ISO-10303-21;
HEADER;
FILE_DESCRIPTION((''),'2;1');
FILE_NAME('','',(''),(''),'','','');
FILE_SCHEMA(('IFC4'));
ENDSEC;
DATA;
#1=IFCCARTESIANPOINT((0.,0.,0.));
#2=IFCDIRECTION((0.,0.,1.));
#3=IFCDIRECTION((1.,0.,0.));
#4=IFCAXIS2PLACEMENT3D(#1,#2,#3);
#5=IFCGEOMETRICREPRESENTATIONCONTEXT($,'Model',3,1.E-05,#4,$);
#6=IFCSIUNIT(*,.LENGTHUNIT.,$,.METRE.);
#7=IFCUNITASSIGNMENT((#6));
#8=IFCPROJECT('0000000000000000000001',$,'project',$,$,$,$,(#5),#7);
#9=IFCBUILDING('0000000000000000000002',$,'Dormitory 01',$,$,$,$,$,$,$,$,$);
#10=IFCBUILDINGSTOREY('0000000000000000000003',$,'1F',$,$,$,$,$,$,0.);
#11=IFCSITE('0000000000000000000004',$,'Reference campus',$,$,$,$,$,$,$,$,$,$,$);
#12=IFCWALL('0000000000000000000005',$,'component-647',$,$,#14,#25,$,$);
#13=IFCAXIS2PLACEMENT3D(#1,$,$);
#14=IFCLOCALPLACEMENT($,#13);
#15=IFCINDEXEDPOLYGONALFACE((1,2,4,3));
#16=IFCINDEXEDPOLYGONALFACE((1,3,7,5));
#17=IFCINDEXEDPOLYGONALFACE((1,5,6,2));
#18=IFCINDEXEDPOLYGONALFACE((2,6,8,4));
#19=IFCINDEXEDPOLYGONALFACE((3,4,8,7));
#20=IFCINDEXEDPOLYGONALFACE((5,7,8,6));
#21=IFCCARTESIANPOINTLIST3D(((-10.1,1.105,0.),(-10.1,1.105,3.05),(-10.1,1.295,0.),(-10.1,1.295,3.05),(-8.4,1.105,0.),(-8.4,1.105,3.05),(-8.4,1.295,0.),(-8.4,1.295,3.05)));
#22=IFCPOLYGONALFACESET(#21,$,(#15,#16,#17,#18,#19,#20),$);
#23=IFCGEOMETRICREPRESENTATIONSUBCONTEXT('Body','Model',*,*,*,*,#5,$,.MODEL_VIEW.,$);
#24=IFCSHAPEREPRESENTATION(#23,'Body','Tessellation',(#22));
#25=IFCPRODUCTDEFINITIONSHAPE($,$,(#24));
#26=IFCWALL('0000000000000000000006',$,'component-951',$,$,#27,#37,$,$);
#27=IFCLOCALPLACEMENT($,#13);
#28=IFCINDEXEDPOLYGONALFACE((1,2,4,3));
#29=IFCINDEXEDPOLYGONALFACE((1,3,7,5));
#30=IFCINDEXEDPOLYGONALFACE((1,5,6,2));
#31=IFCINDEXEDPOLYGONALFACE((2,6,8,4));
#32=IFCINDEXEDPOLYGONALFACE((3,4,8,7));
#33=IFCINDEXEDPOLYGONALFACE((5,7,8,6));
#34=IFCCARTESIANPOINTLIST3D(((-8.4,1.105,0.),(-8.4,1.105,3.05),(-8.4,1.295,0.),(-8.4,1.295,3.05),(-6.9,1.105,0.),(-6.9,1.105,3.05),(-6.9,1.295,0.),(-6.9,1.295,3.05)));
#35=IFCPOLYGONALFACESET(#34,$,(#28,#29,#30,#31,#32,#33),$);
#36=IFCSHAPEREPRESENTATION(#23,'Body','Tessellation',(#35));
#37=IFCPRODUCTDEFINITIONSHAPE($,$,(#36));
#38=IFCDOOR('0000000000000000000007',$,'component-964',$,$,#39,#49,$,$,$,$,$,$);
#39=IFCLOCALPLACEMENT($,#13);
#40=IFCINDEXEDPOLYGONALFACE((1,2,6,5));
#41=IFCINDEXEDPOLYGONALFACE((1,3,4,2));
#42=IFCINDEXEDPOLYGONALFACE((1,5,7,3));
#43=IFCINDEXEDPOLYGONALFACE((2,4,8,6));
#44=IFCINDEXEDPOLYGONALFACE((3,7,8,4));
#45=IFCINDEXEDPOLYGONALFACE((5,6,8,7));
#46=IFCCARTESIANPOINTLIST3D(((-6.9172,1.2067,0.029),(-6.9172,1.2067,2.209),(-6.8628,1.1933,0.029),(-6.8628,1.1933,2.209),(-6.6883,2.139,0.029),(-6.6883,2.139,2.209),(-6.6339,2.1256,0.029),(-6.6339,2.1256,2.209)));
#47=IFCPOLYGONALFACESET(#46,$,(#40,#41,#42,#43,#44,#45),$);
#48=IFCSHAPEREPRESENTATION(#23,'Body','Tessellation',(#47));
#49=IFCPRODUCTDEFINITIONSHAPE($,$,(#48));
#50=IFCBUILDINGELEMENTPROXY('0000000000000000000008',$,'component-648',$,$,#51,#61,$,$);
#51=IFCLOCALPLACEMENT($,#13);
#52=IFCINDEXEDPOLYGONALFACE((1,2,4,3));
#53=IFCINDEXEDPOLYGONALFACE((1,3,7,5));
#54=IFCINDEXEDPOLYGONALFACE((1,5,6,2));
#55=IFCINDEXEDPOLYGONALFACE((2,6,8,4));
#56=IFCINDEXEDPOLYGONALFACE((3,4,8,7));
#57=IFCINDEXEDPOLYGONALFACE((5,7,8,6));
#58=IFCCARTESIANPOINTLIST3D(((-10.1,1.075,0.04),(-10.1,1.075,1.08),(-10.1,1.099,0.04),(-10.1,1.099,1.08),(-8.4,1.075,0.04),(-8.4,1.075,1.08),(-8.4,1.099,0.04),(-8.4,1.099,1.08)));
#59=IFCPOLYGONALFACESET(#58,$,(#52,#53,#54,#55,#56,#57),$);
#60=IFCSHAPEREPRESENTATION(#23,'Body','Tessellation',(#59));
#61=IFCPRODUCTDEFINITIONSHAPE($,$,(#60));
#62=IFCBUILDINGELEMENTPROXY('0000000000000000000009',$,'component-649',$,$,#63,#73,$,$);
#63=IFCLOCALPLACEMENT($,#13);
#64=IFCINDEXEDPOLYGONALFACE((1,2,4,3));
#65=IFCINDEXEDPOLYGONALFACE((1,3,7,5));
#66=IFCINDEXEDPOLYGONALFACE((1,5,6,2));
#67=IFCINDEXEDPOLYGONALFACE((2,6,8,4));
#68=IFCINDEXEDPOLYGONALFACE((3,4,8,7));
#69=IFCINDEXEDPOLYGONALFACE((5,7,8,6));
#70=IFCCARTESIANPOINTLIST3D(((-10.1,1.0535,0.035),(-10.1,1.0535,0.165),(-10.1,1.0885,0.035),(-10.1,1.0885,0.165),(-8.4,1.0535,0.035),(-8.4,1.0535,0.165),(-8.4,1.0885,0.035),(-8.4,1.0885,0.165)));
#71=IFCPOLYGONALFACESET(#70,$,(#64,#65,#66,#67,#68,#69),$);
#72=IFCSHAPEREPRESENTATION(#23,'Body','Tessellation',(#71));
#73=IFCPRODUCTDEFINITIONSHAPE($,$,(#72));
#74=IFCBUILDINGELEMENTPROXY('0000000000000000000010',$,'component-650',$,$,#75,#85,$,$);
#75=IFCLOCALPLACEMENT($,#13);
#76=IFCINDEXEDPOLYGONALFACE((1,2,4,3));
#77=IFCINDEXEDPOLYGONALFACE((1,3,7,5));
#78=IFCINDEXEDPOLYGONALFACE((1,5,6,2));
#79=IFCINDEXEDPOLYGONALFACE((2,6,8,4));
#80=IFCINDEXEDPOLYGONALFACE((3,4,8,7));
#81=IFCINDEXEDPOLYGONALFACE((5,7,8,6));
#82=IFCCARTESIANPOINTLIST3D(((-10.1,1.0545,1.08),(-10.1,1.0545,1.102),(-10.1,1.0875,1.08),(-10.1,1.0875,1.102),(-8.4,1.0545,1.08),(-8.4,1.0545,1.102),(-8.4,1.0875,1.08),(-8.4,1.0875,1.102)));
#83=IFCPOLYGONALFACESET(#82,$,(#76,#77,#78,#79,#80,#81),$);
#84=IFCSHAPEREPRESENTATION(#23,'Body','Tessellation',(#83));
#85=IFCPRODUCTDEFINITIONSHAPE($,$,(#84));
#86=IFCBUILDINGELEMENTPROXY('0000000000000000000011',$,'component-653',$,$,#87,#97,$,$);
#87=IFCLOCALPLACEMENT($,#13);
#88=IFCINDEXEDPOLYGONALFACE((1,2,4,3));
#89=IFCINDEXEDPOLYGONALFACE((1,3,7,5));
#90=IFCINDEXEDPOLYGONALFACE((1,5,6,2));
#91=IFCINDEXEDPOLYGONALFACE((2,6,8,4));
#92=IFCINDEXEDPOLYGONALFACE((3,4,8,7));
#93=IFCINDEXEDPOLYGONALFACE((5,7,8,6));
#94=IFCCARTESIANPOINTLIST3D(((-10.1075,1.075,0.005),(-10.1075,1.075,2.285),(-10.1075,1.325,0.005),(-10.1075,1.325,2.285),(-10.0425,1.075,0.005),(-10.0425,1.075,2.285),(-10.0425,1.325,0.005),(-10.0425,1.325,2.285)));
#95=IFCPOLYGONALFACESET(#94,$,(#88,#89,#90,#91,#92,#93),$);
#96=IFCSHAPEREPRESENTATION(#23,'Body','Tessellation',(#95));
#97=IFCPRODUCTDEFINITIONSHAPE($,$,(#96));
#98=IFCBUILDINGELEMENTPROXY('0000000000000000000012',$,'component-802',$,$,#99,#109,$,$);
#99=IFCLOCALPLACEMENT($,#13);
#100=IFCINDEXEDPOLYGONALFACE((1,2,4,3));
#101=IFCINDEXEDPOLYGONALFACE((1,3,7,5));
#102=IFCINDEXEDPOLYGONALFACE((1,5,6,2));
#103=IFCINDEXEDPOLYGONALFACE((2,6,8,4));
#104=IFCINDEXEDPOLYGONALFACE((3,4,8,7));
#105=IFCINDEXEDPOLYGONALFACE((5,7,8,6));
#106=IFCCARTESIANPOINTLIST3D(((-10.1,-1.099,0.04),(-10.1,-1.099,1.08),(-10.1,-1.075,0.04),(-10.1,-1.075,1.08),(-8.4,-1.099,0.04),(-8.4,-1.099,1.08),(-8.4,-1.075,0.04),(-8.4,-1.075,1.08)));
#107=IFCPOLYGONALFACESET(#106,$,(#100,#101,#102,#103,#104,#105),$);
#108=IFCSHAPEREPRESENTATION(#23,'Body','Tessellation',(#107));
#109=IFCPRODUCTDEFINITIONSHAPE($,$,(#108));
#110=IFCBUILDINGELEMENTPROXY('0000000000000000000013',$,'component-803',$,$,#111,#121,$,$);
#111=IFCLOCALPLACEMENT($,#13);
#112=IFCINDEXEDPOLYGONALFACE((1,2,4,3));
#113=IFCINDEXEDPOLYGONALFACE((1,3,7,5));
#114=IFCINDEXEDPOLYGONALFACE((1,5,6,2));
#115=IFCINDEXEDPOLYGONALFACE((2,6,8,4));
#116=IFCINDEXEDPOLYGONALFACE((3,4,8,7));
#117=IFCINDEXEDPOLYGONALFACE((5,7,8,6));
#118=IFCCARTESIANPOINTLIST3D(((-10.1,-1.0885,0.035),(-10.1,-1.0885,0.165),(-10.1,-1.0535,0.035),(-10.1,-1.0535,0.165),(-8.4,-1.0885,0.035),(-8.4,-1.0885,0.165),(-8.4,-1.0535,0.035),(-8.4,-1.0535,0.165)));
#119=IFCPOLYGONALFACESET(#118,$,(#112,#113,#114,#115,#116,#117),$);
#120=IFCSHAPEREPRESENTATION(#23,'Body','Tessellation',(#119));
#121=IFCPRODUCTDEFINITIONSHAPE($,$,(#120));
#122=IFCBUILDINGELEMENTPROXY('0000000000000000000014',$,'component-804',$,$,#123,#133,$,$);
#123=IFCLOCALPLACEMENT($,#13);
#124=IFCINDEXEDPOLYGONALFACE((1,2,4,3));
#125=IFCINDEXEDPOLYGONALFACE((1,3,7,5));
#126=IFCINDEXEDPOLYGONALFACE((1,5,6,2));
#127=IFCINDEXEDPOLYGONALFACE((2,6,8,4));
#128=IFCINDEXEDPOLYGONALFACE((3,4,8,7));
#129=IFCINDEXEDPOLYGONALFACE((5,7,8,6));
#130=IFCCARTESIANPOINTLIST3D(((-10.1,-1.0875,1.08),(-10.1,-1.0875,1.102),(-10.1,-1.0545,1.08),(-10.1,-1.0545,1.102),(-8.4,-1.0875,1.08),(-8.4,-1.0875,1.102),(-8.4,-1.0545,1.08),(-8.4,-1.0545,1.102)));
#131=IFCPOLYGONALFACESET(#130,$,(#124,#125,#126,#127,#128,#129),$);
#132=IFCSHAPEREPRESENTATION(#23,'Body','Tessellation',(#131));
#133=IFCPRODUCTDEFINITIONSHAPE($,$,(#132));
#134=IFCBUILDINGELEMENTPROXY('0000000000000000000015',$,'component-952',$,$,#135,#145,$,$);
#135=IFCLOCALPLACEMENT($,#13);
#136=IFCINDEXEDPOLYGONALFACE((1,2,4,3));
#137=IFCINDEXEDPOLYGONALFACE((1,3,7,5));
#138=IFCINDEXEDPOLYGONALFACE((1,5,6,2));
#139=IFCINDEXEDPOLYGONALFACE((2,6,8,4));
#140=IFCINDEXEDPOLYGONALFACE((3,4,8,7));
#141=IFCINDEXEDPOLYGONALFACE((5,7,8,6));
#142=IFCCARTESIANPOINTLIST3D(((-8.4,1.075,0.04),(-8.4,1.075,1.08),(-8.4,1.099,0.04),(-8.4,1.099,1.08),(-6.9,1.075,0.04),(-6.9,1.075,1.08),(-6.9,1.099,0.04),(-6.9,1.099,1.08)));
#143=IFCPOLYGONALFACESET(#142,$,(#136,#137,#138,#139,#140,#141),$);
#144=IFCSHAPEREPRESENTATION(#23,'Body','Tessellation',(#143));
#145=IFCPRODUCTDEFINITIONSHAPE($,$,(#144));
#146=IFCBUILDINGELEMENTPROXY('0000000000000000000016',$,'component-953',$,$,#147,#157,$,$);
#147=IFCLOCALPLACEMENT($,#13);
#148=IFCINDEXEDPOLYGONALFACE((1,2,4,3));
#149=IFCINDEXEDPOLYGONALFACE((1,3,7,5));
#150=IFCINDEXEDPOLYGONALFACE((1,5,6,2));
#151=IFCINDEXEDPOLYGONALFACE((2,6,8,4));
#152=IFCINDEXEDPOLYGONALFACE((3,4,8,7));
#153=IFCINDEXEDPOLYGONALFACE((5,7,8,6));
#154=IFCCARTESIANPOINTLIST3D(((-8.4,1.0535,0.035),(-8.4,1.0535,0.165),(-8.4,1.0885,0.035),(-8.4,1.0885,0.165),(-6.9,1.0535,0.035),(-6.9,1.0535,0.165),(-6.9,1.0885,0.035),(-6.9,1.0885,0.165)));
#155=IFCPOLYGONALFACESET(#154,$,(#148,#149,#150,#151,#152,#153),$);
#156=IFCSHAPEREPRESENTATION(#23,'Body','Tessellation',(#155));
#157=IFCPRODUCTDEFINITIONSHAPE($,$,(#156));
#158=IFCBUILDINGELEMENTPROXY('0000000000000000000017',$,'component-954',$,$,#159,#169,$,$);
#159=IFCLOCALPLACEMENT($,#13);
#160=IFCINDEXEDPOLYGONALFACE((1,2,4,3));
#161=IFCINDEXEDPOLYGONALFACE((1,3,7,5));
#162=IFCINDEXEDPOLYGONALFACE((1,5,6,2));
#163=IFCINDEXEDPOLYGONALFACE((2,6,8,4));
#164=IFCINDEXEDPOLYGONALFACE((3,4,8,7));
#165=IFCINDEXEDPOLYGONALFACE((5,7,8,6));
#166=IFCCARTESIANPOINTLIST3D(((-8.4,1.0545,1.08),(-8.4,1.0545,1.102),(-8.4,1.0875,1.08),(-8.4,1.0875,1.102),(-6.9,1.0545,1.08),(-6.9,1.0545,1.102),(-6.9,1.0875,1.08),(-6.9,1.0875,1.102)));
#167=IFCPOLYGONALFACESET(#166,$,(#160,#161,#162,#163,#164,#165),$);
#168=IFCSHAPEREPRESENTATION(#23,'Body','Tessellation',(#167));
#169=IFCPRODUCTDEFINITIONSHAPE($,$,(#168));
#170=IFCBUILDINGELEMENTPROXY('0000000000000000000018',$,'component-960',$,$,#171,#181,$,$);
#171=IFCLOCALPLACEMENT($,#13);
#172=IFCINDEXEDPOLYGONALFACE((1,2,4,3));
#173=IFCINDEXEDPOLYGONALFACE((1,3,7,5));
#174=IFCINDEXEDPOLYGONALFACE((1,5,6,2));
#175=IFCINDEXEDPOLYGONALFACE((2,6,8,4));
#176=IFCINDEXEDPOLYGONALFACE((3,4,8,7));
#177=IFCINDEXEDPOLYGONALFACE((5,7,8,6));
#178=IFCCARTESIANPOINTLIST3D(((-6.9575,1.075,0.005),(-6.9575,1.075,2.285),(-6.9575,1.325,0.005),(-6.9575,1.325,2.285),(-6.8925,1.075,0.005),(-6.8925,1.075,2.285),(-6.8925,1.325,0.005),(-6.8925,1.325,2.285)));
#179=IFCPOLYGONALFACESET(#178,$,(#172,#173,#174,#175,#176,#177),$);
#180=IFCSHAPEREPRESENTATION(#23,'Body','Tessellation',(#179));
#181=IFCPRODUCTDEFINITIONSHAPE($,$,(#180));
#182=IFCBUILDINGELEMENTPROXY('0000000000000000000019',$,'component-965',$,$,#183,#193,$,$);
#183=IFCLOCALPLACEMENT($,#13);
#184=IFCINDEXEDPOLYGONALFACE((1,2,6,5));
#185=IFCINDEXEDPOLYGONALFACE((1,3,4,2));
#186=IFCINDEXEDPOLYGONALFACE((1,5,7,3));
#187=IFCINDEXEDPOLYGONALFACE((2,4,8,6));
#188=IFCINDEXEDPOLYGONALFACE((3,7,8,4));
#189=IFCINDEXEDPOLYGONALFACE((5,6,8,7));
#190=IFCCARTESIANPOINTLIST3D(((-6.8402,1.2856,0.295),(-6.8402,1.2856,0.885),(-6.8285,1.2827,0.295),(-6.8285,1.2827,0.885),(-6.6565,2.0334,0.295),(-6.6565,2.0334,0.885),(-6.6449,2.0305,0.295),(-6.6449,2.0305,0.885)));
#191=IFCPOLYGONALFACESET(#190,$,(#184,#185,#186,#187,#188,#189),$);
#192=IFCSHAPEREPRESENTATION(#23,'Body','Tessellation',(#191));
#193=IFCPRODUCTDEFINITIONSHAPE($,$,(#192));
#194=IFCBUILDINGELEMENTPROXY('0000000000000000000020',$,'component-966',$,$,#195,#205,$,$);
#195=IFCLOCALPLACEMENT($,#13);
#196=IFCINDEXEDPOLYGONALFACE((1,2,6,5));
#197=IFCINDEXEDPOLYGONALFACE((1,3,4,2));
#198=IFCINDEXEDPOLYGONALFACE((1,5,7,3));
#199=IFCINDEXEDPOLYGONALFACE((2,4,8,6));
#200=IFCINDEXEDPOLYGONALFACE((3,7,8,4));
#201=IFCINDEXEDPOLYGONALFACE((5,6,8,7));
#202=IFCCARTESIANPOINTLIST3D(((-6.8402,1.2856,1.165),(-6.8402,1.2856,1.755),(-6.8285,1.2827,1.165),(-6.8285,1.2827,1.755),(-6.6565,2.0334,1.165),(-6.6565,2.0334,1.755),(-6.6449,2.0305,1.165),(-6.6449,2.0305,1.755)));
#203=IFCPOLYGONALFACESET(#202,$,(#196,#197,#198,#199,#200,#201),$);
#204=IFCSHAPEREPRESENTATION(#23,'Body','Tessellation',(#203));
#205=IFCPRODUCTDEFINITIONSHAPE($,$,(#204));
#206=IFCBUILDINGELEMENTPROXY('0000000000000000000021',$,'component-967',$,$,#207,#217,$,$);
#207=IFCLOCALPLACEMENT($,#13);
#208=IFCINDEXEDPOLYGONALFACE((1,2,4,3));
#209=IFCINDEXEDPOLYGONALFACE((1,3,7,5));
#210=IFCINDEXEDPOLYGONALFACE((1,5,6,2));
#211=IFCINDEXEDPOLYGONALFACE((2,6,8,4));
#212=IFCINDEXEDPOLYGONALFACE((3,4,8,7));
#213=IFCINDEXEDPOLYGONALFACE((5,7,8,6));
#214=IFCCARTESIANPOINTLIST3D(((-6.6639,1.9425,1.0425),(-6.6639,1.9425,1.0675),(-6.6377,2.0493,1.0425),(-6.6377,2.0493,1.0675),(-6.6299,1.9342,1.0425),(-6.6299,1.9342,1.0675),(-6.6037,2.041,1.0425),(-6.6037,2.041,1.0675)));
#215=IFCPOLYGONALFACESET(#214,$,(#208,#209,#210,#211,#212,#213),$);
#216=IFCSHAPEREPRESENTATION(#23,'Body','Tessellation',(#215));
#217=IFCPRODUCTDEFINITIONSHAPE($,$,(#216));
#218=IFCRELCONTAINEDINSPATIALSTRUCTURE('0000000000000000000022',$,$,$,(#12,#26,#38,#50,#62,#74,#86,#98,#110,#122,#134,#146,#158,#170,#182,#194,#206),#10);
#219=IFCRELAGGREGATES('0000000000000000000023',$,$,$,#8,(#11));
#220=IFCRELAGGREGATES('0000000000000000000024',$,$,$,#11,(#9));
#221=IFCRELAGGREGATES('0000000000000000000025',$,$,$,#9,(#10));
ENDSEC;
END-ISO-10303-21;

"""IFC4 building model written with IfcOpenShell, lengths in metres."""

from ifc_helpers import new_model, si_unit, frame, origin, origin_with_axes, origin_2d, place, context, subcontext, project, spatial, rectangle, extrude, element, save


model = new_model("IFC4")

# Units and contexts
model_context = context("Model", 3, precision=1e-05, world=origin_with_axes())
body_context = subcontext(model_context, "Body", "Model", "MODEL_VIEW")
ifc_project = project(units=[si_unit("LENGTHUNIT", "METRE")], contexts=[model_context])

# Site, building, storey
site = spatial("IfcSite", under=ifc_project, Name="Reference campus")
building = spatial("IfcBuilding", under=site, Name="Dormitory 01")
storey = spatial("IfcBuildingStorey", under=building, Name="1F", Elevation=0.0)

# Walls
wall_1_placement = place(None, frame((-9.25, 1.2, 0.0), z_axis=(0.0, 0.0, 1.0), x_axis=(1.0, 0.0, 0.0)))
element("IfcWall", 1, at=wall_1_placement, inside=storey, Name="component-647", context=body_context, shape_type="SweptSolid", body=[
    extrude(rectangle(XDim=1.7, YDim=0.19, at=origin_2d()), origin(), (0.0, 0.0, 1.0), 3.05),
])
wall_2_placement = place(None, frame((-7.65, 1.2, 0.0), z_axis=(0.0, 0.0, 1.0), x_axis=(1.0, 0.0, 0.0)))
element("IfcWall", 2, at=wall_2_placement, inside=storey, Name="component-951", context=body_context, shape_type="SweptSolid", body=[
    extrude(rectangle(XDim=1.5, YDim=0.19, at=origin_2d()), origin(), (0.0, 0.0, 1.0), 3.05),
])

# Door
door_placement = place(None, frame((-6.7755, 1.6662, 0.029), z_axis=(0.0, 0.0, 1.0), x_axis=(0.238476, 0.971148, 0.0)))
element("IfcDoor", 3, at=door_placement, inside=storey, Name="component-964", context=body_context, shape_type="SweptSolid", body=[
    extrude(rectangle(XDim=0.96, YDim=0.056, at=origin_2d()), origin(), (0.0, 0.0, 1.0), 2.18),
])

# Building element proxies
proxy_1_placement = place(None, frame((-9.25, 1.087, 0.04), z_axis=(0.0, 0.0, 1.0), x_axis=(1.0, 0.0, 0.0)))
element("IfcBuildingElementProxy", 4, at=proxy_1_placement, inside=storey, Name="component-648", context=body_context, shape_type="SweptSolid", body=[
    extrude(rectangle(XDim=1.7, YDim=0.024, at=origin_2d()), origin(), (0.0, 0.0, 1.0), 1.04),
])
proxy_2_placement = place(None, frame((-9.25, 1.071, 0.035), z_axis=(0.0, 0.0, 1.0), x_axis=(1.0, 0.0, 0.0)))
element("IfcBuildingElementProxy", 5, at=proxy_2_placement, inside=storey, Name="component-649", context=body_context, shape_type="SweptSolid", body=[
    extrude(rectangle(XDim=1.7, YDim=0.035, at=origin_2d()), origin(), (0.0, 0.0, 1.0), 0.13),
])
proxy_3_placement = place(None, frame((-9.25, 1.071, 1.08), z_axis=(0.0, 0.0, 1.0), x_axis=(1.0, 0.0, 0.0)))
element("IfcBuildingElementProxy", 6, at=proxy_3_placement, inside=storey, Name="component-650", context=body_context, shape_type="SweptSolid", body=[
    extrude(rectangle(XDim=1.7, YDim=0.033, at=origin_2d()), origin(), (0.0, 0.0, 1.0), 0.022),
])
proxy_4_placement = place(None, frame((-10.075, 1.2, 0.005), z_axis=(0.0, 0.0, 1.0), x_axis=(1.0, 0.0, 0.0)))
element("IfcBuildingElementProxy", 7, at=proxy_4_placement, inside=storey, Name="component-653", context=body_context, shape_type="SweptSolid", body=[
    extrude(rectangle(XDim=0.065, YDim=0.25, at=origin_2d()), origin(), (0.0, 0.0, 1.0), 2.28),
])
proxy_5_placement = place(None, frame((-9.25, -1.087, 0.04), z_axis=(0.0, 0.0, 1.0), x_axis=(1.0, 0.0, 0.0)))
element("IfcBuildingElementProxy", 8, at=proxy_5_placement, inside=storey, Name="component-802", context=body_context, shape_type="SweptSolid", body=[
    extrude(rectangle(XDim=1.7, YDim=0.024, at=origin_2d()), origin(), (0.0, 0.0, 1.0), 1.04),
])
proxy_6_placement = place(None, frame((-9.25, -1.071, 0.035), z_axis=(0.0, 0.0, 1.0), x_axis=(1.0, 0.0, 0.0)))
element("IfcBuildingElementProxy", 9, at=proxy_6_placement, inside=storey, Name="component-803", context=body_context, shape_type="SweptSolid", body=[
    extrude(rectangle(XDim=1.7, YDim=0.035, at=origin_2d()), origin(), (0.0, 0.0, 1.0), 0.13),
])
proxy_7_placement = place(None, frame((-9.25, -1.071, 1.08), z_axis=(0.0, 0.0, 1.0), x_axis=(1.0, 0.0, 0.0)))
element("IfcBuildingElementProxy", 10, at=proxy_7_placement, inside=storey, Name="component-804", context=body_context, shape_type="SweptSolid", body=[
    extrude(rectangle(XDim=1.7, YDim=0.033, at=origin_2d()), origin(), (0.0, 0.0, 1.0), 0.022),
])
proxy_8_placement = place(None, frame((-7.65, 1.087, 0.04), z_axis=(0.0, 0.0, 1.0), x_axis=(1.0, 0.0, 0.0)))
element("IfcBuildingElementProxy", 11, at=proxy_8_placement, inside=storey, Name="component-952", context=body_context, shape_type="SweptSolid", body=[
    extrude(rectangle(XDim=1.5, YDim=0.024, at=origin_2d()), origin(), (0.0, 0.0, 1.0), 1.04),
])
proxy_9_placement = place(None, frame((-7.65, 1.071, 0.035), z_axis=(0.0, 0.0, 1.0), x_axis=(1.0, 0.0, 0.0)))
element("IfcBuildingElementProxy", 12, at=proxy_9_placement, inside=storey, Name="component-953", context=body_context, shape_type="SweptSolid", body=[
    extrude(rectangle(XDim=1.5, YDim=0.035, at=origin_2d()), origin(), (0.0, 0.0, 1.0), 0.13),
])
proxy_10_placement = place(None, frame((-7.65, 1.071, 1.08), z_axis=(0.0, 0.0, 1.0), x_axis=(1.0, 0.0, 0.0)))
element("IfcBuildingElementProxy", 13, at=proxy_10_placement, inside=storey, Name="component-954", context=body_context, shape_type="SweptSolid", body=[
    extrude(rectangle(XDim=1.5, YDim=0.033, at=origin_2d()), origin(), (0.0, 0.0, 1.0), 0.022),
])
proxy_11_placement = place(None, frame((-6.925, 1.2, 0.005), z_axis=(0.0, 0.0, 1.0), x_axis=(1.0, 0.0, 0.0)))
element("IfcBuildingElementProxy", 14, at=proxy_11_placement, inside=storey, Name="component-960", context=body_context, shape_type="SweptSolid", body=[
    extrude(rectangle(XDim=0.065, YDim=0.25, at=origin_2d()), origin(), (0.0, 0.0, 1.0), 2.28),
])
for number, where, z_axis, x_axis, name in (
    (15, (-6.7425, 1.658, 0.295), (0.0, 0.0, 1.0), (0.238476, 0.971148, 0.0), "component-965"),
    (16, (-6.7425, 1.658, 1.165), (0.0, 0.0, 1.0), (0.238476, 0.971148, 0.0), "component-966"),
):
    element("IfcBuildingElementProxy", number, at=place(None, frame(where, z_axis=z_axis, x_axis=x_axis)), inside=storey, Name=name, context=body_context, shape_type="SweptSolid", body=[
        extrude(rectangle(XDim=0.77, YDim=0.012, at=origin_2d()), origin(), (0.0, 0.0, 1.0), 0.59),
    ])
proxy_12_placement = place(None, frame((-6.6338, 1.9917, 1.0425), z_axis=(0.0, 0.0, 1.0), x_axis=(0.238476, 0.971148, 0.0)))
element("IfcBuildingElementProxy", 17, at=proxy_12_placement, inside=storey, Name="component-967", context=body_context, shape_type="SweptSolid", body=[
    extrude(rectangle(XDim=0.11, YDim=0.035, at=origin_2d()), origin(), (0.0, 0.0, 1.0), 0.025),
])

save(model, "model.ifc")
